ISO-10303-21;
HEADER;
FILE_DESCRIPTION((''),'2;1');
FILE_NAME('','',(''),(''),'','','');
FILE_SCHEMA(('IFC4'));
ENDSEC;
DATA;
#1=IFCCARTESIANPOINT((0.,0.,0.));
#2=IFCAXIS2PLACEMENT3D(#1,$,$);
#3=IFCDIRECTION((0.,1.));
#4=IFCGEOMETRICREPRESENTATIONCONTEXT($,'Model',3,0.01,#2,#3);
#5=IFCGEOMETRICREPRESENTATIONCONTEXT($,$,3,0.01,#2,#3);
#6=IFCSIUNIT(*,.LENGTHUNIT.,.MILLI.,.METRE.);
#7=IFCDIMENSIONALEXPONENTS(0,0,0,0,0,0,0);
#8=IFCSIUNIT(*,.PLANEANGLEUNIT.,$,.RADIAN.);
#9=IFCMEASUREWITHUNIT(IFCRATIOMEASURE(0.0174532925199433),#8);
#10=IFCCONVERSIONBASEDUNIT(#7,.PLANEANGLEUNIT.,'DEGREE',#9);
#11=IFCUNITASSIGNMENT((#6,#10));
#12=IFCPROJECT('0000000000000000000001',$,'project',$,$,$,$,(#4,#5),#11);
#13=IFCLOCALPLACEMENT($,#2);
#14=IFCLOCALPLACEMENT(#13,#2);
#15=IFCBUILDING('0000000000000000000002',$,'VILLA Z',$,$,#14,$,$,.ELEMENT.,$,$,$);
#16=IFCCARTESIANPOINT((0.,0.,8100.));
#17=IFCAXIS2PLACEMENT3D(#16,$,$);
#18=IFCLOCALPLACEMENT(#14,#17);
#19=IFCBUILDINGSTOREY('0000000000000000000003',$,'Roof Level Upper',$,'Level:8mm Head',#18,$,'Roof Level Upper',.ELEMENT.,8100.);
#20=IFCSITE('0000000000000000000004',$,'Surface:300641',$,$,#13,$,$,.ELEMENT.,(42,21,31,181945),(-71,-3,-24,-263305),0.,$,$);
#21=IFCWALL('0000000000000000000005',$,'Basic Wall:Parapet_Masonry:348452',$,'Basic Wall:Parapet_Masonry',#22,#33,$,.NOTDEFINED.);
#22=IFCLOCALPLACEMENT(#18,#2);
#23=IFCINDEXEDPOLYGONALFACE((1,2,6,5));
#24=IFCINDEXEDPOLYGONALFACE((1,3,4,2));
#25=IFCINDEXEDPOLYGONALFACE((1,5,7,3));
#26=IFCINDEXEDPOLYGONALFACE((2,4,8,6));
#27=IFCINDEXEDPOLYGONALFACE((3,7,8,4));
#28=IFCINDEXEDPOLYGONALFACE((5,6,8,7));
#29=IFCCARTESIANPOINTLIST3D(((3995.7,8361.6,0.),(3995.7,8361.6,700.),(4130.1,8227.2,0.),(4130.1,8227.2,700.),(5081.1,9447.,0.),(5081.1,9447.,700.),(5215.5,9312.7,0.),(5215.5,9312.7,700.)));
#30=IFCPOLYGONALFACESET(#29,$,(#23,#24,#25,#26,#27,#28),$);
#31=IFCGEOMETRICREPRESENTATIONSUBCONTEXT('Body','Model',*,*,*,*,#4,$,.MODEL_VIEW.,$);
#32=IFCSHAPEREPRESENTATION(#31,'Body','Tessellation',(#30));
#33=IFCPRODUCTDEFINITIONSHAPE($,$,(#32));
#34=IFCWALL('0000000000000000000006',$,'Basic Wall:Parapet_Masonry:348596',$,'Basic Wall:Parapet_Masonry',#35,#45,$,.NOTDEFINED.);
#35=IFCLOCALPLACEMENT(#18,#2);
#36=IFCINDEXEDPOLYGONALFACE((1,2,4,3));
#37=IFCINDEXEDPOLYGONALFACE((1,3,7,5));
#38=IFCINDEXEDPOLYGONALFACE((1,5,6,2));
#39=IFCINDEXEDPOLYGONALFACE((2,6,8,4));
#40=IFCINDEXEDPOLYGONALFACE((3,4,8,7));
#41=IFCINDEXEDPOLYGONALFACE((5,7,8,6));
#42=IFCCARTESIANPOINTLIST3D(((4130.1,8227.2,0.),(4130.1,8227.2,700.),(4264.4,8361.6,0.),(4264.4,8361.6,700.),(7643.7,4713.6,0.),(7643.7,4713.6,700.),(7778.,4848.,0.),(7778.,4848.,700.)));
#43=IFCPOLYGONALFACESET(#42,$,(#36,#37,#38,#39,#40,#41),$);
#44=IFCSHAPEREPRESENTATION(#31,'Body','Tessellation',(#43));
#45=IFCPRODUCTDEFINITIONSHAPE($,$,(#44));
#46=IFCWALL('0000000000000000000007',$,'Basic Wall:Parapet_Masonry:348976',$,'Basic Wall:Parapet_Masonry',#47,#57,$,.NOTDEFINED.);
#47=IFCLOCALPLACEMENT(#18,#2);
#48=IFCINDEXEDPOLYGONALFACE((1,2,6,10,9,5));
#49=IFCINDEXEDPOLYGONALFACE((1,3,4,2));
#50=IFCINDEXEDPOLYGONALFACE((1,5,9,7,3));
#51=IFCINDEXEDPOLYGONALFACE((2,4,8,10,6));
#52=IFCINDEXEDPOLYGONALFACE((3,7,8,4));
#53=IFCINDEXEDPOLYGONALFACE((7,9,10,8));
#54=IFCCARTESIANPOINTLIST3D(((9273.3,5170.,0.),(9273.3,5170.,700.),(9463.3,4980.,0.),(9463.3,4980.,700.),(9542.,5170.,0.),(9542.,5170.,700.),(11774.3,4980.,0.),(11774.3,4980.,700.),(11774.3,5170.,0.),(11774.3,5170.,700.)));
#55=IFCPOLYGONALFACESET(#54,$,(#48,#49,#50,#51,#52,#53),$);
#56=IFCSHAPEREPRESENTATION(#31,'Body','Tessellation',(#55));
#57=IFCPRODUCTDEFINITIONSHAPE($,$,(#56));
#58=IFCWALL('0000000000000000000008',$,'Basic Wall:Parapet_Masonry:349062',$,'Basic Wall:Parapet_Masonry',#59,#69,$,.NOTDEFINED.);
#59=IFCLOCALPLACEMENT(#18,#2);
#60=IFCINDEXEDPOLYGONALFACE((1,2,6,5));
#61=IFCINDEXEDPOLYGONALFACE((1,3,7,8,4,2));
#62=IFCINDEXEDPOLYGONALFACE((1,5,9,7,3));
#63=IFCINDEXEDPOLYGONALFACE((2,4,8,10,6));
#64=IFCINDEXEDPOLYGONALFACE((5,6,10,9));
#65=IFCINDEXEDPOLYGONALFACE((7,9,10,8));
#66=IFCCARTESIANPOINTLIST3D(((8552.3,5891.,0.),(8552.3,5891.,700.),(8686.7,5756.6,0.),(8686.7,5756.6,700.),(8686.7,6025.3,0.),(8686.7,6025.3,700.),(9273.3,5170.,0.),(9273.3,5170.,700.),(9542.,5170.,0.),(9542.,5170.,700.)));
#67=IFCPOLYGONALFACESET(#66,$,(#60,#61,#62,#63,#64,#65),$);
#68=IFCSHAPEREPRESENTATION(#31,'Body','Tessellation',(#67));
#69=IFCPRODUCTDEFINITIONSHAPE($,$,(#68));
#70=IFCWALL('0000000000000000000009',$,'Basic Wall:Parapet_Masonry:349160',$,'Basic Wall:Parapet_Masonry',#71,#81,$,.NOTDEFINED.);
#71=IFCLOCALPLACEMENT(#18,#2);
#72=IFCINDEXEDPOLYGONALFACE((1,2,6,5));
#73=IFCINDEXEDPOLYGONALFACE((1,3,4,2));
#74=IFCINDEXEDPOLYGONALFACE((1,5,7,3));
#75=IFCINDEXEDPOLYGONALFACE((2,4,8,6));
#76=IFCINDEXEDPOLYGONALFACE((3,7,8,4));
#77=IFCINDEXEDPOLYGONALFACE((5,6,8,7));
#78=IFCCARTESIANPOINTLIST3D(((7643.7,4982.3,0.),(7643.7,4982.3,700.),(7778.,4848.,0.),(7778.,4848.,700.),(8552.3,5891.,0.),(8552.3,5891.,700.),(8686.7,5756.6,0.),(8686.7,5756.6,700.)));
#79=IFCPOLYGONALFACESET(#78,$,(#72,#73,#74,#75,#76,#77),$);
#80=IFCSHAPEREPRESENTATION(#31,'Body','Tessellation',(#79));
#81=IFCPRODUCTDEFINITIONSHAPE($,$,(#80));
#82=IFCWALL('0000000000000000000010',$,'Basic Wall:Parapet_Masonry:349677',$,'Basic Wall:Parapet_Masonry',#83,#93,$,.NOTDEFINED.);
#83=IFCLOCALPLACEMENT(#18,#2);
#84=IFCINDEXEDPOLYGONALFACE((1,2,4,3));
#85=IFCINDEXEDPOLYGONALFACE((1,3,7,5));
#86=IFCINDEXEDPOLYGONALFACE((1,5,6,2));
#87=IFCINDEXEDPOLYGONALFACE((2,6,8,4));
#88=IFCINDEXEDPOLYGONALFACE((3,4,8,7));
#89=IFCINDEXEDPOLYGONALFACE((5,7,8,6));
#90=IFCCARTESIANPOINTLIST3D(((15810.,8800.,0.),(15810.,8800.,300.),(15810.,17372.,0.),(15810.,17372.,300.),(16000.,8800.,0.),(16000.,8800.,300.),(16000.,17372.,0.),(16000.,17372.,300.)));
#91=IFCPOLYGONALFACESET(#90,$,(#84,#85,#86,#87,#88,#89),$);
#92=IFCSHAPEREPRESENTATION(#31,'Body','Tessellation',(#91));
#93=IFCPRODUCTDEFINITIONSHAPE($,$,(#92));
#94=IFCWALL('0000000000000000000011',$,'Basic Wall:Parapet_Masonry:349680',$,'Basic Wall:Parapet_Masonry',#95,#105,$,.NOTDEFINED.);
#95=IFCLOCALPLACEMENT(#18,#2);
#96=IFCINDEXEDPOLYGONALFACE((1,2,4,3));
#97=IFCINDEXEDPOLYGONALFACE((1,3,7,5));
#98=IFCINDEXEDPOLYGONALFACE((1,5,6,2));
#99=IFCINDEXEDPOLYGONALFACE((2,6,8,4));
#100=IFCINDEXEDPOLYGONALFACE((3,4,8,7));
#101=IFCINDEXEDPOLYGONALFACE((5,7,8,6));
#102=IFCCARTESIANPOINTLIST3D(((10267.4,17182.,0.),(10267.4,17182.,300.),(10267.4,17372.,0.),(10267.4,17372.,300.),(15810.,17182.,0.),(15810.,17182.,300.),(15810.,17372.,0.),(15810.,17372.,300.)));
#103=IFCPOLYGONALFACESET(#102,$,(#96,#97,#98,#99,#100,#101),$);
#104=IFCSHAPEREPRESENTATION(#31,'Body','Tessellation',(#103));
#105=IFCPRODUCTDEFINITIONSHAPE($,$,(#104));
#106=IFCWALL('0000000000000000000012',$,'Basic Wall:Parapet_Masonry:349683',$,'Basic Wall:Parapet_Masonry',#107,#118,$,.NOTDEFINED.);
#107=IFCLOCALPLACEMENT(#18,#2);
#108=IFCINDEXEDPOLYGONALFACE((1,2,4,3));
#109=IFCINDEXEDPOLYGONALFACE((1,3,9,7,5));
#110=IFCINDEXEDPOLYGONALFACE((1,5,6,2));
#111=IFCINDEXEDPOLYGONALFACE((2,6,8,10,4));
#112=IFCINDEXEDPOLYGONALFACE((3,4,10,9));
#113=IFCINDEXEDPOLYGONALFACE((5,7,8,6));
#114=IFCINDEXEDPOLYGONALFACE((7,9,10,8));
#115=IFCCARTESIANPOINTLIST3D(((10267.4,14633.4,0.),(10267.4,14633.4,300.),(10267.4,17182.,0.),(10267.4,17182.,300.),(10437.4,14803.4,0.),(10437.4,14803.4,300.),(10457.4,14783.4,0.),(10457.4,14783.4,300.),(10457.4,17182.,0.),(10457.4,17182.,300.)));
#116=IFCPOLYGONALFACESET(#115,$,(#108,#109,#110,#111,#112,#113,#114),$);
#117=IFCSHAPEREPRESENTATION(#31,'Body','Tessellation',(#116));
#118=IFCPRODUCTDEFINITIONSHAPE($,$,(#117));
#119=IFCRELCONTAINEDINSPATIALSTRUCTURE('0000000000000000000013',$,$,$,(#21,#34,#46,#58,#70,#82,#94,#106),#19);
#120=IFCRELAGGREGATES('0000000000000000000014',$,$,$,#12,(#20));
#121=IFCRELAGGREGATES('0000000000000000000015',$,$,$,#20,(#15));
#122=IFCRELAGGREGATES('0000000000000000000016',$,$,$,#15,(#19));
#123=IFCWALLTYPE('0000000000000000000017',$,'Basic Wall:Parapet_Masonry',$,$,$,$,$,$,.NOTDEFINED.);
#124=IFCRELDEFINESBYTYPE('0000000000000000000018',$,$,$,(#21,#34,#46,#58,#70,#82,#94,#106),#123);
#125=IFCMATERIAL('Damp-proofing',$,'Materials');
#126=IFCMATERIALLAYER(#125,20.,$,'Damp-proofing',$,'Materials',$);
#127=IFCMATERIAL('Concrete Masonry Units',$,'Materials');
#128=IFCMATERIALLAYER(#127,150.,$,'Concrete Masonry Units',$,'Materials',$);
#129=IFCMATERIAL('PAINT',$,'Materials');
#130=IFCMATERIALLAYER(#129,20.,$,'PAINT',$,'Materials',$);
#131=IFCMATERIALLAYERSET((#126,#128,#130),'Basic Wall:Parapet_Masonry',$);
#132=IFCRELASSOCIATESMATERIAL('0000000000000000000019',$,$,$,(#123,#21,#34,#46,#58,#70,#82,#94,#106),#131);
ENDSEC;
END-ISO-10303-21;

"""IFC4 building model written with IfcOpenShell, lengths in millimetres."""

from ifc_helpers import new_model, entity, si_unit, converted_unit, direction, frame, frame_2d, origin, place, context, subcontext, project, spatial, polyline, rectangle, outline, extrude, clip, halfspace, material, layer, layer_set, layer_usage, type_object, element, save


model = new_model("IFC4")

# Units and contexts
model_context = context("Model", 3, precision=0.01, world=origin(), true_north=direction((0.0, 1.0)))
context_of_model = context(None, 3, precision=0.01, world=origin(), true_north=direction((0.0, 1.0)))
body_context = subcontext(model_context, "Body", "Model", "MODEL_VIEW")
ifc_project = project(units=[si_unit("LENGTHUNIT", "METRE", prefix="MILLI"), converted_unit("PLANEANGLEUNIT", "DEGREE", entity("IfcRatioMeasure", 0.0174532925199433), si_unit("PLANEANGLEUNIT", "RADIAN"), dimensions=[0, 0, 0, 0, 0, 0, 0])], contexts=[model_context, context_of_model])

# Site, building, storey
site_placement = place(None, origin())
site = spatial("IfcSite", under=ifc_project, at=site_placement, Name="Surface:300641", CompositionType="ELEMENT", RefLatitude=(42, 21, 31, 181945), RefLongitude=(-71, -3, -24, -263305), RefElevation=0.0)
building_placement = place(site_placement, origin())
building = spatial("IfcBuilding", under=site, at=building_placement, Name="VILLA Z", CompositionType="ELEMENT")
storey_placement = place(building_placement, frame((0.0, 0.0, 8100.0)))
storey = spatial("IfcBuildingStorey", under=building, at=storey_placement, Name="Roof Level Upper", ObjectType="Level:8mm Head", LongName="Roof Level Upper", CompositionType="ELEMENT", Elevation=8100.0)

# Shared definitions
ifc_material_1 = material(Name="Damp-proofing", Category="Materials")

# Walls
ifc_layer_1 = layer(ifc_material_1, 20.0, Name="Damp-proofing", Category="Materials")
ifc_material_2 = material(Name="Concrete Masonry Units", Category="Materials")
ifc_layer_2 = layer(ifc_material_2, 150.0, Name="Concrete Masonry Units", Category="Materials")
ifc_material_3 = material(Name="PAINT", Category="Materials")
ifc_layer_3 = layer(ifc_material_3, 20.0, Name="PAINT", Category="Materials")
ifc_layer_set_1 = layer_set([ifc_layer_1, ifc_layer_2, ifc_layer_3], Name="Basic Wall:Parapet_Masonry")
wall_type = type_object("IfcWallType", Name="Basic Wall:Parapet_Masonry", PredefinedType="NOTDEFINED", material=ifc_layer_set_1)
ifc_layer_usage_1 = layer_usage(ifc_layer_set_1, "AXIS2", "NEGATIVE", 95.0)
wall_1_placement = place(storey_placement, frame((5148.3, 9379.8, 0.0), z_axis=(0.0, 0.0, 1.0), x_axis=(-0.707107, -0.707107, 0.0)))
element("IfcWall", 1, at=wall_1_placement, inside=storey, type_object=wall_type, material=ifc_layer_usage_1, Name="Basic Wall:Parapet_Masonry:348452", ObjectType="Basic Wall:Parapet_Masonry", PredefinedType="NOTDEFINED", context=body_context, shape_type="SweptSolid", body=[
    extrude(rectangle(XDim=1535.0, YDim=190.0, at=frame_2d((767.5, 0.0), x_axis=(-1.0, 0.0))), origin(), (0.0, 0.0, 1.0), 700.0),
])
ifc_layer_usage_2 = layer_usage(ifc_layer_set_1, "AXIS2", "NEGATIVE", 95.0)
wall_2_placement = place(storey_placement, frame((4197.2, 8294.4, 0.0), z_axis=(0.0, 0.0, 1.0), x_axis=(0.707107, -0.707107, 0.0)))
element("IfcWall", 2, at=wall_2_placement, inside=storey, type_object=wall_type, material=ifc_layer_usage_2, Name="Basic Wall:Parapet_Masonry:348596", ObjectType="Basic Wall:Parapet_Masonry", PredefinedType="NOTDEFINED", context=body_context, shape_type="SweptSolid", body=[
    extrude(rectangle(XDim=4969.0, YDim=190.0, at=frame_2d((2484.5, 0.0), x_axis=(-1.0, 0.0))), origin(), (0.0, 0.0, 1.0), 700.0),
])
ifc_layer_usage_3 = layer_usage(ifc_layer_set_1, "AXIS2", "POSITIVE", -95.0)
wall_3_placement = place(storey_placement, frame((11774.3, 5075.0, 0.0), z_axis=(0.0, 0.0, 1.0), x_axis=(-1.0, 0.0, 0.0)))
element("IfcWall", 3, at=wall_3_placement, inside=storey, type_object=wall_type, material=ifc_layer_usage_3, Name="Basic Wall:Parapet_Masonry:348976", ObjectType="Basic Wall:Parapet_Masonry", PredefinedType="NOTDEFINED", context=body_context, shape_type="SweptSolid", body=[
    extrude(outline(polyline([(2501.0, -95.0), (2311.0, 95.0), (0.0, 95.0), (0.0, -95.0), (2232.3, -95.0), (2501.0, -95.0)])), origin(), (0.0, 0.0, 1.0), 700.0),
])
ifc_layer_usage_4 = layer_usage(ifc_layer_set_1, "AXIS2", "POSITIVE", -95.0)
wall_4_placement = place(storey_placement, frame((9474.8, 5102.8, 0.0), z_axis=(0.0, 0.0, 1.0), x_axis=(-0.707107, 0.707107, 0.0)))
element("IfcWall", 4, at=wall_4_placement, inside=storey, type_object=wall_type, material=ifc_layer_usage_4, Name="Basic Wall:Parapet_Masonry:349062", ObjectType="Basic Wall:Parapet_Masonry", PredefinedType="NOTDEFINED", context=body_context, shape_type="SweptSolid", body=[
    extrude(outline(polyline([(1209.6, -95.0), (1209.6, 95.0), (1019.6, 95.0), (190.0, 95.0), (0.0, -95.0), (1209.6, -95.0)])), origin(), (0.0, 0.0, 1.0), 700.0),
])
ifc_layer_usage_5 = layer_usage(ifc_layer_set_1, "AXIS2", "POSITIVE", -95.0)
wall_5_placement = place(storey_placement, frame((8619.5, 5823.8, 0.0), z_axis=(0.0, 0.0, 1.0), x_axis=(-0.707107, -0.707107, 0.0)))
element("IfcWall", 5, at=wall_5_placement, inside=storey, type_object=wall_type, material=ifc_layer_usage_5, Name="Basic Wall:Parapet_Masonry:349160", ObjectType="Basic Wall:Parapet_Masonry", PredefinedType="NOTDEFINED", context=body_context, shape_type="SweptSolid", body=[
    extrude(rectangle(XDim=1285.0, YDim=190.0, at=frame_2d((642.5, 0.0), x_axis=(-1.0, 0.0))), origin(), (0.0, 0.0, 1.0), 700.0),
])
ifc_layer_usage_6 = layer_usage(ifc_layer_set_1, "AXIS2", "NEGATIVE", 95.0)
wall_6_placement = place(storey_placement, frame((15905.0, 8800.0, 0.0), z_axis=(0.0, 0.0, 1.0), x_axis=(0.0, 1.0, 0.0)))
element("IfcWall", 6, at=wall_6_placement, inside=storey, type_object=wall_type, material=ifc_layer_usage_6, Name="Basic Wall:Parapet_Masonry:349677", ObjectType="Basic Wall:Parapet_Masonry", PredefinedType="NOTDEFINED", context=body_context, shape_type="Clipping", body=[
    clip(extrude(rectangle(XDim=8572.0, YDim=190.0, at=frame_2d((4286.0, 0.0), x_axis=(-1.0, 0.0))), origin(), (0.0, 0.0, 1.0), 300.0), halfspace(frame((0.0, 0.0, -400.0)), True)),
])
ifc_layer_usage_7 = layer_usage(ifc_layer_set_1, "AXIS2", "NEGATIVE", 95.0)
wall_7_placement = place(storey_placement, frame((15810.0, 17277.0, 0.0), z_axis=(0.0, 0.0, 1.0), x_axis=(-1.0, 0.0, 0.0)))
element("IfcWall", 7, at=wall_7_placement, inside=storey, type_object=wall_type, material=ifc_layer_usage_7, Name="Basic Wall:Parapet_Masonry:349680", ObjectType="Basic Wall:Parapet_Masonry", PredefinedType="NOTDEFINED", context=body_context, shape_type="Clipping", body=[
    clip(extrude(rectangle(XDim=5542.6, YDim=190.0, at=frame_2d((2771.3, 0.0), x_axis=(-1.0, 0.0))), origin(), (0.0, 0.0, 1.0), 300.0), halfspace(frame((0.0, 0.0, -400.0)), True)),
])
ifc_layer_usage_8 = layer_usage(ifc_layer_set_1, "AXIS2", "NEGATIVE", 95.0)
wall_8_placement = place(storey_placement, frame((10362.4, 17182.0, 0.0), z_axis=(0.0, 0.0, 1.0), x_axis=(0.0, -1.0, 0.0)))
element("IfcWall", 8, at=wall_8_placement, inside=storey, type_object=wall_type, material=ifc_layer_usage_8, Name="Basic Wall:Parapet_Masonry:349683", ObjectType="Basic Wall:Parapet_Masonry", PredefinedType="NOTDEFINED", context=body_context, shape_type="Clipping", body=[
    clip(extrude(outline(polyline([(2548.6, -95.0), (2378.6, 75.0), (2398.6, 95.0), (0.0, 95.0), (0.0, -95.0), (2548.6, -95.0)])), origin(), (0.0, 0.0, 1.0), 300.0), halfspace(frame((0.0, 0.0, -400.0)), True)),
])

save(model, "model.ifc")
